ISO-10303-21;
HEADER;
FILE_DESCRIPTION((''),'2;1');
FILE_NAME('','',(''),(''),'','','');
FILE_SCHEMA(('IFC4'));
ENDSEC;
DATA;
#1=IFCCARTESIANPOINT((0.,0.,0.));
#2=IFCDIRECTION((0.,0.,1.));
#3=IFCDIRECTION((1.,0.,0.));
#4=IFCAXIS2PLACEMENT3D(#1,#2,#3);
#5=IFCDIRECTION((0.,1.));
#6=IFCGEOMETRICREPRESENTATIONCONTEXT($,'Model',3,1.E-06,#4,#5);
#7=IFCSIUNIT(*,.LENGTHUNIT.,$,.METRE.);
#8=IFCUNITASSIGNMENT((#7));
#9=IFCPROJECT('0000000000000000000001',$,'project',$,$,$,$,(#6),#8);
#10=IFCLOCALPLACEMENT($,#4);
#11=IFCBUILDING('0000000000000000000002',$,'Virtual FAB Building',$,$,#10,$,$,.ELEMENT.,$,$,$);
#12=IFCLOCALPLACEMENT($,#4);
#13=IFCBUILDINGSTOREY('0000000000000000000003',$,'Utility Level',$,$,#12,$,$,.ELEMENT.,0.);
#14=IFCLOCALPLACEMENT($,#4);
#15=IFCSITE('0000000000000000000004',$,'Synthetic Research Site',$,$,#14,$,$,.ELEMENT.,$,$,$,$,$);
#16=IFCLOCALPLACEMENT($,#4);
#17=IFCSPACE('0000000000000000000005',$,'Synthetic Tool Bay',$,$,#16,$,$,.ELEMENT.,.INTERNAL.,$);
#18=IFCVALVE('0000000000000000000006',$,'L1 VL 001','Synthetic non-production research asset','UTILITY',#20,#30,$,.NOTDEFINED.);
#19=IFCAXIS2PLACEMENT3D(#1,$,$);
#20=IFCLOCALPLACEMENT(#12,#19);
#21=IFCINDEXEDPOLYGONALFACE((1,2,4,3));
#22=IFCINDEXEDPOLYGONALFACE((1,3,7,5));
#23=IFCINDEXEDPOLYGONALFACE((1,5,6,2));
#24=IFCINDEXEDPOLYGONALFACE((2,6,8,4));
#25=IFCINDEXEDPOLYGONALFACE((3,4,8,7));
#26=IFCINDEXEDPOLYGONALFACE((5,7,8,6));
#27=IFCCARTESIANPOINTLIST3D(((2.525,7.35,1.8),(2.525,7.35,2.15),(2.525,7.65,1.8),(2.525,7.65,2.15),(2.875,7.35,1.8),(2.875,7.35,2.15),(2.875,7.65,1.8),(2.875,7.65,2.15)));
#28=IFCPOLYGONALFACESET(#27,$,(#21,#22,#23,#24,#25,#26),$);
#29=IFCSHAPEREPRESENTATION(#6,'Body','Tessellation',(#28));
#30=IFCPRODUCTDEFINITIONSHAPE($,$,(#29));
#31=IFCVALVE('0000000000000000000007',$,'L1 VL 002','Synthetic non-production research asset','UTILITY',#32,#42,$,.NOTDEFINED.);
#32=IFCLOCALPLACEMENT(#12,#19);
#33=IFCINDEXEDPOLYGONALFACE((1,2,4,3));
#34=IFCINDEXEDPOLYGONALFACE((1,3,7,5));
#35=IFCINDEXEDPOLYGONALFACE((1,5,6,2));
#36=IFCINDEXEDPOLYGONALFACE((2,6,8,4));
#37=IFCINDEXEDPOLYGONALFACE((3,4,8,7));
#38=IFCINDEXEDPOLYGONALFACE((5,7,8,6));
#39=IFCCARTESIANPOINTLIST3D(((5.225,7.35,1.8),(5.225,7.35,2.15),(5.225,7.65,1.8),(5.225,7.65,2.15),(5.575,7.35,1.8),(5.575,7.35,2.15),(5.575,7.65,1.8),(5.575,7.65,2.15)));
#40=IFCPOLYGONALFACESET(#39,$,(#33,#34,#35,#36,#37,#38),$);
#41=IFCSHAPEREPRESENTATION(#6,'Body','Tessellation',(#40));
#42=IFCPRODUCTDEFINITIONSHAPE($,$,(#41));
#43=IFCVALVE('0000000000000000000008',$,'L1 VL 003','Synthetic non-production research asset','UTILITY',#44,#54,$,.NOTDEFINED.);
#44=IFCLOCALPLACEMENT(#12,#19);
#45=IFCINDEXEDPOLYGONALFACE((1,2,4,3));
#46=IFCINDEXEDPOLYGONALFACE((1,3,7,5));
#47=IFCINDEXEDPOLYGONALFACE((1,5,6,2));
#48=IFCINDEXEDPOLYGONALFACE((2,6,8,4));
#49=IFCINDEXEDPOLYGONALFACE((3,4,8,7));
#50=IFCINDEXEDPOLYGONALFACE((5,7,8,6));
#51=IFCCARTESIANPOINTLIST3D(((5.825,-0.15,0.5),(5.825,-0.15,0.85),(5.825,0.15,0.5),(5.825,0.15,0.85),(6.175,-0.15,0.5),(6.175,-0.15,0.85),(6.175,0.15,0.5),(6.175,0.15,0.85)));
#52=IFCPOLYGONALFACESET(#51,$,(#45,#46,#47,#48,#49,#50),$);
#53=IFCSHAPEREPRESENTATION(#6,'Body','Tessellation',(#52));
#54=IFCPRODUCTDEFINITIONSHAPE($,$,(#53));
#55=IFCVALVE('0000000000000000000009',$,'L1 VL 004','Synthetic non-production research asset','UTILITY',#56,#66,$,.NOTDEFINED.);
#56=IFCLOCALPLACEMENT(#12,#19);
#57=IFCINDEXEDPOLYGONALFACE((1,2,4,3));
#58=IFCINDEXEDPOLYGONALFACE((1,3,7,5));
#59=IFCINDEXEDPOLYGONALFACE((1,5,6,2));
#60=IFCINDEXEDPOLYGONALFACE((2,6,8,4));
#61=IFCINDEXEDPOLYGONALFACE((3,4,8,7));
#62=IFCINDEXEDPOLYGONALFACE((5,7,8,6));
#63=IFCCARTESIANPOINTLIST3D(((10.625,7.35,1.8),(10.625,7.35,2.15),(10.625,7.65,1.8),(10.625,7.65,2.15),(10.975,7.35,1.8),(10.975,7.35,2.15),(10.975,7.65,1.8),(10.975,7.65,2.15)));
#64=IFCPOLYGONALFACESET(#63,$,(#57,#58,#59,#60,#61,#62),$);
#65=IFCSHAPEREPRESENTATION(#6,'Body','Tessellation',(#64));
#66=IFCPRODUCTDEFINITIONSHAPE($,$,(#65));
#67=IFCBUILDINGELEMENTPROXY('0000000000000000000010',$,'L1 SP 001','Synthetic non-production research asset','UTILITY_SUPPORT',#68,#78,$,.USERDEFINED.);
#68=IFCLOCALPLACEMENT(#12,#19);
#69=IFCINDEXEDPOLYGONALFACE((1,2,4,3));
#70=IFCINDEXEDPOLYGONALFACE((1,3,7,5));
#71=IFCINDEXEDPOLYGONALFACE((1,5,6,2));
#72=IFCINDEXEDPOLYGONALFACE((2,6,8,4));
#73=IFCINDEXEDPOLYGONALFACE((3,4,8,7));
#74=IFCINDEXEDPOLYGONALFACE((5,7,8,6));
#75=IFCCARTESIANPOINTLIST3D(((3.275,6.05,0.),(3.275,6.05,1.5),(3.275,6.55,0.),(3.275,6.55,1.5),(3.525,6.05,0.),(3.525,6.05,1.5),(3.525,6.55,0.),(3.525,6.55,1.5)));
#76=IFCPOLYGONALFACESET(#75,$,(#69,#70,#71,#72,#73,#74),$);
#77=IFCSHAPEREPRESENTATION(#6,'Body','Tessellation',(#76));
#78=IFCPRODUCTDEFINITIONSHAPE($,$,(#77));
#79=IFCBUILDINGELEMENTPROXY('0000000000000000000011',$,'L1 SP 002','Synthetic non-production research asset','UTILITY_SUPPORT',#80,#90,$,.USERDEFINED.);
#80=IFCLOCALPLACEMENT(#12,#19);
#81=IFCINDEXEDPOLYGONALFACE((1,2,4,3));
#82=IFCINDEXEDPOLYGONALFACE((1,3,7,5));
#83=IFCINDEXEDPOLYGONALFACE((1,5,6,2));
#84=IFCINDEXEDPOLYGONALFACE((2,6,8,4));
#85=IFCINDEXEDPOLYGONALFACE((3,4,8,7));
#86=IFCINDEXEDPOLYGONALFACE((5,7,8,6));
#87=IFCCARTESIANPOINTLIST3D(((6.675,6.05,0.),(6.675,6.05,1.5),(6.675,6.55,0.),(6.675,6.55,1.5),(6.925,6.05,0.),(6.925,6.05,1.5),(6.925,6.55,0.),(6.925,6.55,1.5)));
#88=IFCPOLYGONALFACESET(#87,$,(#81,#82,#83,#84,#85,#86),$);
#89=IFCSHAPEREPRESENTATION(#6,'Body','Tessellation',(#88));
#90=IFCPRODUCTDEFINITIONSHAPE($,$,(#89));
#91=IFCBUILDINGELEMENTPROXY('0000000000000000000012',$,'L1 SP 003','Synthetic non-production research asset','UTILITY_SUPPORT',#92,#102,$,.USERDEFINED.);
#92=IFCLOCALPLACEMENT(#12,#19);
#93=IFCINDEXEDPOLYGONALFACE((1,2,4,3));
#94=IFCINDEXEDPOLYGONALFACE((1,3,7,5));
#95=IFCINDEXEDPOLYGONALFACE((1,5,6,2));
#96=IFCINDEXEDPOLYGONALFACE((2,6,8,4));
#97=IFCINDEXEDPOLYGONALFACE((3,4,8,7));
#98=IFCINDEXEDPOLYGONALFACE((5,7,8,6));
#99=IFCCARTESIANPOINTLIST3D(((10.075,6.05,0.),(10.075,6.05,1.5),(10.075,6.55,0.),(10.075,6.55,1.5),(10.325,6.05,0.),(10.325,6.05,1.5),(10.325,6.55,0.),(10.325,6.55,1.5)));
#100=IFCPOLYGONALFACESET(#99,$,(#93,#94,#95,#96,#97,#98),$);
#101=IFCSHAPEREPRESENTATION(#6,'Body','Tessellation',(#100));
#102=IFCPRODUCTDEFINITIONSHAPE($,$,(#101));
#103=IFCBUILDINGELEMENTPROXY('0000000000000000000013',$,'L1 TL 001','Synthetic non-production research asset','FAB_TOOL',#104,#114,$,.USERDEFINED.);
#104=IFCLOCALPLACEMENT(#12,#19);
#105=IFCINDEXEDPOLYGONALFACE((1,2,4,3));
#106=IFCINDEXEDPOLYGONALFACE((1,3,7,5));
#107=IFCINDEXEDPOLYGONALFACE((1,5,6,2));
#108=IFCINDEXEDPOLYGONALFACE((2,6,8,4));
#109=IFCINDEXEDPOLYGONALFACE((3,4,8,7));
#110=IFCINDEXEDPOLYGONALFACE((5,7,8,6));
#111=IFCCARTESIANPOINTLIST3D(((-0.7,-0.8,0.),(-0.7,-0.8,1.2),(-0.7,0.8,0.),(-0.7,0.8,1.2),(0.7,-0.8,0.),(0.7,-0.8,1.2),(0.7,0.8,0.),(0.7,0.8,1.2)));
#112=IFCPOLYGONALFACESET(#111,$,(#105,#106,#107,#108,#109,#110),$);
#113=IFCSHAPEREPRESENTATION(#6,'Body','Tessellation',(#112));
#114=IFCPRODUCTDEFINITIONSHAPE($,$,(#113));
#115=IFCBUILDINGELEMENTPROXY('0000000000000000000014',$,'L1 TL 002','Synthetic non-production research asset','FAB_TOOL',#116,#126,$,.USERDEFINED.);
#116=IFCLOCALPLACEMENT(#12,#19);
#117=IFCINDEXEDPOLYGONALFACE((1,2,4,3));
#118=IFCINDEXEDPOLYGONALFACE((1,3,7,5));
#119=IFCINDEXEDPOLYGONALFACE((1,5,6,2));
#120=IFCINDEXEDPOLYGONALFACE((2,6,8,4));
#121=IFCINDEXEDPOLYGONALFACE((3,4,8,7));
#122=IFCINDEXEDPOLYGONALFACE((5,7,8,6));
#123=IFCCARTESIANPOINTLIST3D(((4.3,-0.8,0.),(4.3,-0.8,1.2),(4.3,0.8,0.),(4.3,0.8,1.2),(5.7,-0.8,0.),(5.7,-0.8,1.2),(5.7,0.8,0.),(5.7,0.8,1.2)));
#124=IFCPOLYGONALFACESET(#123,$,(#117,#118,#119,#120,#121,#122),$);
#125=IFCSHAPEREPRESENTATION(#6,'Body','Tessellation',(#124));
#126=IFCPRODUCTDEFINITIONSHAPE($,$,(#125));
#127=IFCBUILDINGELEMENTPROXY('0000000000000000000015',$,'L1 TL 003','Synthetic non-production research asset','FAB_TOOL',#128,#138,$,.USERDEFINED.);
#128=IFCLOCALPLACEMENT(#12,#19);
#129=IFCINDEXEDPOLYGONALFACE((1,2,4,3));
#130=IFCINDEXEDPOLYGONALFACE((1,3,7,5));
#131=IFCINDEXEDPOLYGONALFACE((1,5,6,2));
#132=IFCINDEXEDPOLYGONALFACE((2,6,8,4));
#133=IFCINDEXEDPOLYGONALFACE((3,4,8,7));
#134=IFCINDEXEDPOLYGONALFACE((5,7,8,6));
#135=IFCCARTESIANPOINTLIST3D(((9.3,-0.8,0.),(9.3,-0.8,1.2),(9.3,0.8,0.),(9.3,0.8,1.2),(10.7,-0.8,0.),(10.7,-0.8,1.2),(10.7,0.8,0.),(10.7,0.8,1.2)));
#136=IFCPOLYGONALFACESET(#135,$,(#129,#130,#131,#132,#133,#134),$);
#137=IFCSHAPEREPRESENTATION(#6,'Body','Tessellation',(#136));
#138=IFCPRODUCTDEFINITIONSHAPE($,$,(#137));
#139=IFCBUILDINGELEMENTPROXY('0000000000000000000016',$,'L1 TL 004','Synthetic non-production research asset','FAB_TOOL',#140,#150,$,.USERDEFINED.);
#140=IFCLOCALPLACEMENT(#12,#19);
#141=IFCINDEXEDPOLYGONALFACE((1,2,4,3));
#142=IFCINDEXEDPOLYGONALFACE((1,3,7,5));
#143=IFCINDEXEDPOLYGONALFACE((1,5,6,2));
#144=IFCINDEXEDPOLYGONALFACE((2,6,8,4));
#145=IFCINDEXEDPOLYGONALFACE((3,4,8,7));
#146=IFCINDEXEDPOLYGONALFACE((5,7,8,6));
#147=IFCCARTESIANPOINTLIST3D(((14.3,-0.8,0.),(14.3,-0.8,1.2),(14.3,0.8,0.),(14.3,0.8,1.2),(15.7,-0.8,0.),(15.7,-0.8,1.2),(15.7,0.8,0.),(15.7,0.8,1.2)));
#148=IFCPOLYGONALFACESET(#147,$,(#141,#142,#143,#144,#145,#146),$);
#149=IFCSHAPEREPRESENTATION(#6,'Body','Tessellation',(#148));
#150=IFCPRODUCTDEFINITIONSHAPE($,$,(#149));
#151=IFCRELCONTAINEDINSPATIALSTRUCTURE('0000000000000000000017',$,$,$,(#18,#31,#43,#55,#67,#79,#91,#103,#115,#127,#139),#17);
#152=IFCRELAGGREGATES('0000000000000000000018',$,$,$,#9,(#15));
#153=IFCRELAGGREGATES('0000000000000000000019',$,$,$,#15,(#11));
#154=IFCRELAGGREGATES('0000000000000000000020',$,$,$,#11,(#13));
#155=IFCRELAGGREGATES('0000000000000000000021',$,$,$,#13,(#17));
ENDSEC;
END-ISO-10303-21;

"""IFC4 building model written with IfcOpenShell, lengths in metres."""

from ifc_helpers import new_model, si_unit, direction, frame, origin_with_axes, origin_2d_with_axis, place, context, project, spatial, rectangle, extrude, element, save


model = new_model("IFC4")

# Units and contexts
model_context = context("Model", 3, precision=1e-06, world=origin_with_axes(), true_north=direction((0.0, 1.0)))
ifc_project = project(units=[si_unit("LENGTHUNIT", "METRE")], contexts=[model_context])

# Site, building, storey, space
site_placement = place(None, origin_with_axes())
site = spatial("IfcSite", under=ifc_project, at=site_placement, Name="Synthetic Research Site", CompositionType="ELEMENT")
building_placement = place(None, origin_with_axes())
building = spatial("IfcBuilding", under=site, at=building_placement, Name="Virtual FAB Building", CompositionType="ELEMENT")
storey_placement = place(None, origin_with_axes())
storey = spatial("IfcBuildingStorey", under=building, at=storey_placement, Name="Utility Level", CompositionType="ELEMENT", Elevation=0.0)
space_placement = place(None, origin_with_axes())
space = spatial("IfcSpace", under=storey, at=space_placement, Name="Synthetic Tool Bay", CompositionType="ELEMENT", PredefinedType="INTERNAL")

# Valves
for number, where, z_axis, x_axis, name in (
    (1, (2.7, 7.5, 1.8), (0.0, 0.0, 1.0), (1.0, 0.0, 0.0), "L1 VL 001"),
    (2, (5.4, 7.5, 1.8), (0.0, 0.0, 1.0), (1.0, 0.0, 0.0), "L1 VL 002"),
    (3, (6.0, 0.0, 0.5), (0.0, 0.0, 1.0), (1.0, 0.0, 0.0), "L1 VL 003"),
    (4, (10.8, 7.5, 1.8), (0.0, 0.0, 1.0), (1.0, 0.0, 0.0), "L1 VL 004"),
):
    element("IfcValve", number, at=place(None, frame(where, z_axis=z_axis, x_axis=x_axis)), inside=space, Name=name, Description="Synthetic non-production research asset", ObjectType="UTILITY", PredefinedType="NOTDEFINED", context=model_context, shape_type="SweptSolid", body=[
        extrude(rectangle(XDim=0.35, YDim=0.3, at=origin_2d_with_axis()), origin_with_axes(), (0.0, 0.0, 1.0), 0.35),
    ])

# Building element proxies
for number, where, z_axis, x_axis, name in (
    (5, (3.4, 6.3, 0.0), (0.0, 0.0, 1.0), (1.0, 0.0, 0.0), "L1 SP 001"),
    (6, (6.8, 6.3, 0.0), (0.0, 0.0, 1.0), (1.0, 0.0, 0.0), "L1 SP 002"),
    (7, (10.2, 6.3, 0.0), (0.0, 0.0, 1.0), (1.0, 0.0, 0.0), "L1 SP 003"),
):
    element("IfcBuildingElementProxy", number, at=place(None, frame(where, z_axis=z_axis, x_axis=x_axis)), inside=space, Name=name, Description="Synthetic non-production research asset", ObjectType="UTILITY_SUPPORT", PredefinedType="USERDEFINED", context=model_context, shape_type="SweptSolid", body=[
        extrude(rectangle(XDim=0.25, YDim=0.5, at=origin_2d_with_axis()), origin_with_axes(), (0.0, 0.0, 1.0), 1.5),
    ])
for number, where, z_axis, x_axis, name in (
    (8, (0.0, 0.0, 0.0), (0.0, 0.0, 1.0), (1.0, 0.0, 0.0), "L1 TL 001"),
    (9, (5.0, 0.0, 0.0), (0.0, 0.0, 1.0), (1.0, 0.0, 0.0), "L1 TL 002"),
    (10, (10.0, 0.0, 0.0), (0.0, 0.0, 1.0), (1.0, 0.0, 0.0), "L1 TL 003"),
    (11, (15.0, 0.0, 0.0), (0.0, 0.0, 1.0), (1.0, 0.0, 0.0), "L1 TL 004"),
):
    element("IfcBuildingElementProxy", number, at=place(None, frame(where, z_axis=z_axis, x_axis=x_axis)), inside=space, Name=name, Description="Synthetic non-production research asset", ObjectType="FAB_TOOL", PredefinedType="USERDEFINED", context=model_context, shape_type="SweptSolid", body=[
        extrude(rectangle(XDim=1.4, YDim=1.6, at=origin_2d_with_axis()), origin_with_axes(), (0.0, 0.0, 1.0), 1.2),
    ])

save(model, "model.ifc")
